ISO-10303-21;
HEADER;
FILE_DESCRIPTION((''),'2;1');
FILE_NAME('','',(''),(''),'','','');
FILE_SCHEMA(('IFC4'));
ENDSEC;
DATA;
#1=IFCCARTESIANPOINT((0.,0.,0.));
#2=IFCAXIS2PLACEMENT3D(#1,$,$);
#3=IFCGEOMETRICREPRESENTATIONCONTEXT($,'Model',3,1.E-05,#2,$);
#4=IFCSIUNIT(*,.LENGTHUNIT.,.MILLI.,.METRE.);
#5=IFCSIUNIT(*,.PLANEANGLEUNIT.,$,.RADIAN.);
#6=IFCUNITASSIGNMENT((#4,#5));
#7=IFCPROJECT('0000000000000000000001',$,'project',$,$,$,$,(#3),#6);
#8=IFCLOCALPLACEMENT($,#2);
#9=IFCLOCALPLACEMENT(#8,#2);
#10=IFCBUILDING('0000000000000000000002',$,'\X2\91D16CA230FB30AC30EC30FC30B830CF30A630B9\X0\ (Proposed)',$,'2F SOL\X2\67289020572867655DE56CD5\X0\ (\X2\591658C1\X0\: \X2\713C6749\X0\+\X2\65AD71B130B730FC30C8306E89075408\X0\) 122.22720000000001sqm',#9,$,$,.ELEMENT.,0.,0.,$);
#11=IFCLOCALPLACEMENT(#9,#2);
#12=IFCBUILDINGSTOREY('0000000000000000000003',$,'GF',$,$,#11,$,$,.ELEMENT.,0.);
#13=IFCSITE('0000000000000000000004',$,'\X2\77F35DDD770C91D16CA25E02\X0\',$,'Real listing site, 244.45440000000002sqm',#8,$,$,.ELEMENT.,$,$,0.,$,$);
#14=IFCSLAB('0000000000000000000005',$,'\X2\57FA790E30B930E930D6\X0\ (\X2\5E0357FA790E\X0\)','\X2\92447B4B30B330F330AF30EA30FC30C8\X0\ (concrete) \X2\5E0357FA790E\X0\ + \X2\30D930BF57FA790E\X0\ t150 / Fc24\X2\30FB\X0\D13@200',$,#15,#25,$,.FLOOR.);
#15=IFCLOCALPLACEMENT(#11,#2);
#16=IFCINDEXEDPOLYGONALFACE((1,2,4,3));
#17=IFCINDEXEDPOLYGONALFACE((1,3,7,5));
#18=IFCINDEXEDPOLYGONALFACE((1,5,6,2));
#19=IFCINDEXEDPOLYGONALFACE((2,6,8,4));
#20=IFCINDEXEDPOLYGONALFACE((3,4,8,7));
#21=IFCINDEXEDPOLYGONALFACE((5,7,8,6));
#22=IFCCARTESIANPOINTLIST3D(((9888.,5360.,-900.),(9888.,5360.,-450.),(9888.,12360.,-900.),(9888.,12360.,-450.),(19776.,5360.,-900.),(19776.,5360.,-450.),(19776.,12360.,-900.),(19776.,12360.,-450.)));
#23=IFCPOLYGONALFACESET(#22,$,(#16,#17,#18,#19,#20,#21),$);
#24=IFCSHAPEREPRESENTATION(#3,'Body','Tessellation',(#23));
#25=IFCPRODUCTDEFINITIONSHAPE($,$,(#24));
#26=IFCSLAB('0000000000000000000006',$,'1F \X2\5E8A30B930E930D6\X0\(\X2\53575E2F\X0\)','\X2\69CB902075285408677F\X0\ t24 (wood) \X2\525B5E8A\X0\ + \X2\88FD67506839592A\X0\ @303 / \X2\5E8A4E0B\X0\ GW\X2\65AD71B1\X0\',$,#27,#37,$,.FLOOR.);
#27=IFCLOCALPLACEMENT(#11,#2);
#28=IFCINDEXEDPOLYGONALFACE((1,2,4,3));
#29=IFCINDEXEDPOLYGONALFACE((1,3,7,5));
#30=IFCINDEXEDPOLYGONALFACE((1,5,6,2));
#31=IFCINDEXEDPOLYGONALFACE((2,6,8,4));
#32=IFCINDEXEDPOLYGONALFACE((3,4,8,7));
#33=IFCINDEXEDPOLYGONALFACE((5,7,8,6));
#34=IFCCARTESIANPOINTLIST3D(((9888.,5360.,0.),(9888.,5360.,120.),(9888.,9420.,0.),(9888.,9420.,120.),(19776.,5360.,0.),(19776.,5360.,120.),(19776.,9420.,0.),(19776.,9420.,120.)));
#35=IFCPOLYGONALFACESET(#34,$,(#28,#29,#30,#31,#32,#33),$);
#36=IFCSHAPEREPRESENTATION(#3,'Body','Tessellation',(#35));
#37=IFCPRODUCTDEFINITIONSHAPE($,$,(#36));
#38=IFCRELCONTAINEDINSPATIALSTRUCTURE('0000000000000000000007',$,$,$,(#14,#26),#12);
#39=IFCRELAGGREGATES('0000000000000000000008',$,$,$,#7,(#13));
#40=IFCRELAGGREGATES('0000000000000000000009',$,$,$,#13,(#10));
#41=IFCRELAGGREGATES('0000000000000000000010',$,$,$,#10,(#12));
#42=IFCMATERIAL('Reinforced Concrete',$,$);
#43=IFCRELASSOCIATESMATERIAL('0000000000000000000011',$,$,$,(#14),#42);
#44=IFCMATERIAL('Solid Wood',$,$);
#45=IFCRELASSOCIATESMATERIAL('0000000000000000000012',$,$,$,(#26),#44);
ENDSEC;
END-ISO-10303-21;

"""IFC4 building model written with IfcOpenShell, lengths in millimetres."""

from ifc_helpers import new_model, si_unit, frame, frame_2d, origin, place, context, project, spatial, rectangle, extrude, material, element, save


model = new_model("IFC4")

# Units and contexts
model_context = context("Model", 3, precision=1e-05, world=origin())
ifc_project = project(units=[si_unit("LENGTHUNIT", "METRE", prefix="MILLI"), si_unit("PLANEANGLEUNIT", "RADIAN")], contexts=[model_context])

# Site, building, storey
site_placement = place(None, origin())
site = spatial("IfcSite", under=ifc_project, at=site_placement, Name="石川県金沢市", ObjectType="Real listing site, 244.45440000000002sqm", CompositionType="ELEMENT", RefElevation=0.0)
building_placement = place(site_placement, origin())
building = spatial("IfcBuilding", under=site, at=building_placement, Name="金沢・ガレージハウス (Proposed)", ObjectType="2F SOL木造在来工法 (外壁: 焼杉+断熱シートの複合) 122.22720000000001sqm", CompositionType="ELEMENT", ElevationOfRefHeight=0.0, ElevationOfTerrain=0.0)
storey_placement = place(building_placement, origin())
storey = spatial("IfcBuildingStorey", under=building, at=storey_placement, Name="GF", CompositionType="ELEMENT", Elevation=0.0)

# Slabs
ifc_material_1 = material(Name="Reinforced Concrete")
slab_1_placement = place(storey_placement, frame((4944.0, 2680.0, -450.0)))
element("IfcSlab", 1, at=slab_1_placement, inside=storey, material=ifc_material_1, Name="基礎スラブ (布基礎)", Description="鉄筋コンクリート (concrete) 布基礎 + ベタ基礎 t150 / Fc24・D13@200", PredefinedType="FLOOR", context=model_context, shape_type="SweptSolid", body=[
    extrude(rectangle(XDim=9888.0, YDim=7000.0, at=frame_2d((4944.0, 3500.0))), frame((4944.0, 2680.0, -450.0)), (0.0, 0.0, 1.0), 450.0),
])
ifc_material_2 = material(Name="Solid Wood")
slab_2_placement = place(storey_placement, frame((4944.0, 2680.0, 0.0)))
element("IfcSlab", 2, at=slab_2_placement, inside=storey, material=ifc_material_2, Name="1F 床スラブ(南帯)", Description="構造用合板 t24 (wood) 剛床 + 製材根太 @303 / 床下 GW断熱", PredefinedType="FLOOR", context=model_context, shape_type="SweptSolid", body=[
    extrude(rectangle(XDim=9888.0, YDim=4060.0, at=frame_2d((4944.0, 2030.0))), frame((4944.0, 2680.0, 0.0)), (0.0, 0.0, 1.0), 120.0),
])

save(model, "model.ifc")
